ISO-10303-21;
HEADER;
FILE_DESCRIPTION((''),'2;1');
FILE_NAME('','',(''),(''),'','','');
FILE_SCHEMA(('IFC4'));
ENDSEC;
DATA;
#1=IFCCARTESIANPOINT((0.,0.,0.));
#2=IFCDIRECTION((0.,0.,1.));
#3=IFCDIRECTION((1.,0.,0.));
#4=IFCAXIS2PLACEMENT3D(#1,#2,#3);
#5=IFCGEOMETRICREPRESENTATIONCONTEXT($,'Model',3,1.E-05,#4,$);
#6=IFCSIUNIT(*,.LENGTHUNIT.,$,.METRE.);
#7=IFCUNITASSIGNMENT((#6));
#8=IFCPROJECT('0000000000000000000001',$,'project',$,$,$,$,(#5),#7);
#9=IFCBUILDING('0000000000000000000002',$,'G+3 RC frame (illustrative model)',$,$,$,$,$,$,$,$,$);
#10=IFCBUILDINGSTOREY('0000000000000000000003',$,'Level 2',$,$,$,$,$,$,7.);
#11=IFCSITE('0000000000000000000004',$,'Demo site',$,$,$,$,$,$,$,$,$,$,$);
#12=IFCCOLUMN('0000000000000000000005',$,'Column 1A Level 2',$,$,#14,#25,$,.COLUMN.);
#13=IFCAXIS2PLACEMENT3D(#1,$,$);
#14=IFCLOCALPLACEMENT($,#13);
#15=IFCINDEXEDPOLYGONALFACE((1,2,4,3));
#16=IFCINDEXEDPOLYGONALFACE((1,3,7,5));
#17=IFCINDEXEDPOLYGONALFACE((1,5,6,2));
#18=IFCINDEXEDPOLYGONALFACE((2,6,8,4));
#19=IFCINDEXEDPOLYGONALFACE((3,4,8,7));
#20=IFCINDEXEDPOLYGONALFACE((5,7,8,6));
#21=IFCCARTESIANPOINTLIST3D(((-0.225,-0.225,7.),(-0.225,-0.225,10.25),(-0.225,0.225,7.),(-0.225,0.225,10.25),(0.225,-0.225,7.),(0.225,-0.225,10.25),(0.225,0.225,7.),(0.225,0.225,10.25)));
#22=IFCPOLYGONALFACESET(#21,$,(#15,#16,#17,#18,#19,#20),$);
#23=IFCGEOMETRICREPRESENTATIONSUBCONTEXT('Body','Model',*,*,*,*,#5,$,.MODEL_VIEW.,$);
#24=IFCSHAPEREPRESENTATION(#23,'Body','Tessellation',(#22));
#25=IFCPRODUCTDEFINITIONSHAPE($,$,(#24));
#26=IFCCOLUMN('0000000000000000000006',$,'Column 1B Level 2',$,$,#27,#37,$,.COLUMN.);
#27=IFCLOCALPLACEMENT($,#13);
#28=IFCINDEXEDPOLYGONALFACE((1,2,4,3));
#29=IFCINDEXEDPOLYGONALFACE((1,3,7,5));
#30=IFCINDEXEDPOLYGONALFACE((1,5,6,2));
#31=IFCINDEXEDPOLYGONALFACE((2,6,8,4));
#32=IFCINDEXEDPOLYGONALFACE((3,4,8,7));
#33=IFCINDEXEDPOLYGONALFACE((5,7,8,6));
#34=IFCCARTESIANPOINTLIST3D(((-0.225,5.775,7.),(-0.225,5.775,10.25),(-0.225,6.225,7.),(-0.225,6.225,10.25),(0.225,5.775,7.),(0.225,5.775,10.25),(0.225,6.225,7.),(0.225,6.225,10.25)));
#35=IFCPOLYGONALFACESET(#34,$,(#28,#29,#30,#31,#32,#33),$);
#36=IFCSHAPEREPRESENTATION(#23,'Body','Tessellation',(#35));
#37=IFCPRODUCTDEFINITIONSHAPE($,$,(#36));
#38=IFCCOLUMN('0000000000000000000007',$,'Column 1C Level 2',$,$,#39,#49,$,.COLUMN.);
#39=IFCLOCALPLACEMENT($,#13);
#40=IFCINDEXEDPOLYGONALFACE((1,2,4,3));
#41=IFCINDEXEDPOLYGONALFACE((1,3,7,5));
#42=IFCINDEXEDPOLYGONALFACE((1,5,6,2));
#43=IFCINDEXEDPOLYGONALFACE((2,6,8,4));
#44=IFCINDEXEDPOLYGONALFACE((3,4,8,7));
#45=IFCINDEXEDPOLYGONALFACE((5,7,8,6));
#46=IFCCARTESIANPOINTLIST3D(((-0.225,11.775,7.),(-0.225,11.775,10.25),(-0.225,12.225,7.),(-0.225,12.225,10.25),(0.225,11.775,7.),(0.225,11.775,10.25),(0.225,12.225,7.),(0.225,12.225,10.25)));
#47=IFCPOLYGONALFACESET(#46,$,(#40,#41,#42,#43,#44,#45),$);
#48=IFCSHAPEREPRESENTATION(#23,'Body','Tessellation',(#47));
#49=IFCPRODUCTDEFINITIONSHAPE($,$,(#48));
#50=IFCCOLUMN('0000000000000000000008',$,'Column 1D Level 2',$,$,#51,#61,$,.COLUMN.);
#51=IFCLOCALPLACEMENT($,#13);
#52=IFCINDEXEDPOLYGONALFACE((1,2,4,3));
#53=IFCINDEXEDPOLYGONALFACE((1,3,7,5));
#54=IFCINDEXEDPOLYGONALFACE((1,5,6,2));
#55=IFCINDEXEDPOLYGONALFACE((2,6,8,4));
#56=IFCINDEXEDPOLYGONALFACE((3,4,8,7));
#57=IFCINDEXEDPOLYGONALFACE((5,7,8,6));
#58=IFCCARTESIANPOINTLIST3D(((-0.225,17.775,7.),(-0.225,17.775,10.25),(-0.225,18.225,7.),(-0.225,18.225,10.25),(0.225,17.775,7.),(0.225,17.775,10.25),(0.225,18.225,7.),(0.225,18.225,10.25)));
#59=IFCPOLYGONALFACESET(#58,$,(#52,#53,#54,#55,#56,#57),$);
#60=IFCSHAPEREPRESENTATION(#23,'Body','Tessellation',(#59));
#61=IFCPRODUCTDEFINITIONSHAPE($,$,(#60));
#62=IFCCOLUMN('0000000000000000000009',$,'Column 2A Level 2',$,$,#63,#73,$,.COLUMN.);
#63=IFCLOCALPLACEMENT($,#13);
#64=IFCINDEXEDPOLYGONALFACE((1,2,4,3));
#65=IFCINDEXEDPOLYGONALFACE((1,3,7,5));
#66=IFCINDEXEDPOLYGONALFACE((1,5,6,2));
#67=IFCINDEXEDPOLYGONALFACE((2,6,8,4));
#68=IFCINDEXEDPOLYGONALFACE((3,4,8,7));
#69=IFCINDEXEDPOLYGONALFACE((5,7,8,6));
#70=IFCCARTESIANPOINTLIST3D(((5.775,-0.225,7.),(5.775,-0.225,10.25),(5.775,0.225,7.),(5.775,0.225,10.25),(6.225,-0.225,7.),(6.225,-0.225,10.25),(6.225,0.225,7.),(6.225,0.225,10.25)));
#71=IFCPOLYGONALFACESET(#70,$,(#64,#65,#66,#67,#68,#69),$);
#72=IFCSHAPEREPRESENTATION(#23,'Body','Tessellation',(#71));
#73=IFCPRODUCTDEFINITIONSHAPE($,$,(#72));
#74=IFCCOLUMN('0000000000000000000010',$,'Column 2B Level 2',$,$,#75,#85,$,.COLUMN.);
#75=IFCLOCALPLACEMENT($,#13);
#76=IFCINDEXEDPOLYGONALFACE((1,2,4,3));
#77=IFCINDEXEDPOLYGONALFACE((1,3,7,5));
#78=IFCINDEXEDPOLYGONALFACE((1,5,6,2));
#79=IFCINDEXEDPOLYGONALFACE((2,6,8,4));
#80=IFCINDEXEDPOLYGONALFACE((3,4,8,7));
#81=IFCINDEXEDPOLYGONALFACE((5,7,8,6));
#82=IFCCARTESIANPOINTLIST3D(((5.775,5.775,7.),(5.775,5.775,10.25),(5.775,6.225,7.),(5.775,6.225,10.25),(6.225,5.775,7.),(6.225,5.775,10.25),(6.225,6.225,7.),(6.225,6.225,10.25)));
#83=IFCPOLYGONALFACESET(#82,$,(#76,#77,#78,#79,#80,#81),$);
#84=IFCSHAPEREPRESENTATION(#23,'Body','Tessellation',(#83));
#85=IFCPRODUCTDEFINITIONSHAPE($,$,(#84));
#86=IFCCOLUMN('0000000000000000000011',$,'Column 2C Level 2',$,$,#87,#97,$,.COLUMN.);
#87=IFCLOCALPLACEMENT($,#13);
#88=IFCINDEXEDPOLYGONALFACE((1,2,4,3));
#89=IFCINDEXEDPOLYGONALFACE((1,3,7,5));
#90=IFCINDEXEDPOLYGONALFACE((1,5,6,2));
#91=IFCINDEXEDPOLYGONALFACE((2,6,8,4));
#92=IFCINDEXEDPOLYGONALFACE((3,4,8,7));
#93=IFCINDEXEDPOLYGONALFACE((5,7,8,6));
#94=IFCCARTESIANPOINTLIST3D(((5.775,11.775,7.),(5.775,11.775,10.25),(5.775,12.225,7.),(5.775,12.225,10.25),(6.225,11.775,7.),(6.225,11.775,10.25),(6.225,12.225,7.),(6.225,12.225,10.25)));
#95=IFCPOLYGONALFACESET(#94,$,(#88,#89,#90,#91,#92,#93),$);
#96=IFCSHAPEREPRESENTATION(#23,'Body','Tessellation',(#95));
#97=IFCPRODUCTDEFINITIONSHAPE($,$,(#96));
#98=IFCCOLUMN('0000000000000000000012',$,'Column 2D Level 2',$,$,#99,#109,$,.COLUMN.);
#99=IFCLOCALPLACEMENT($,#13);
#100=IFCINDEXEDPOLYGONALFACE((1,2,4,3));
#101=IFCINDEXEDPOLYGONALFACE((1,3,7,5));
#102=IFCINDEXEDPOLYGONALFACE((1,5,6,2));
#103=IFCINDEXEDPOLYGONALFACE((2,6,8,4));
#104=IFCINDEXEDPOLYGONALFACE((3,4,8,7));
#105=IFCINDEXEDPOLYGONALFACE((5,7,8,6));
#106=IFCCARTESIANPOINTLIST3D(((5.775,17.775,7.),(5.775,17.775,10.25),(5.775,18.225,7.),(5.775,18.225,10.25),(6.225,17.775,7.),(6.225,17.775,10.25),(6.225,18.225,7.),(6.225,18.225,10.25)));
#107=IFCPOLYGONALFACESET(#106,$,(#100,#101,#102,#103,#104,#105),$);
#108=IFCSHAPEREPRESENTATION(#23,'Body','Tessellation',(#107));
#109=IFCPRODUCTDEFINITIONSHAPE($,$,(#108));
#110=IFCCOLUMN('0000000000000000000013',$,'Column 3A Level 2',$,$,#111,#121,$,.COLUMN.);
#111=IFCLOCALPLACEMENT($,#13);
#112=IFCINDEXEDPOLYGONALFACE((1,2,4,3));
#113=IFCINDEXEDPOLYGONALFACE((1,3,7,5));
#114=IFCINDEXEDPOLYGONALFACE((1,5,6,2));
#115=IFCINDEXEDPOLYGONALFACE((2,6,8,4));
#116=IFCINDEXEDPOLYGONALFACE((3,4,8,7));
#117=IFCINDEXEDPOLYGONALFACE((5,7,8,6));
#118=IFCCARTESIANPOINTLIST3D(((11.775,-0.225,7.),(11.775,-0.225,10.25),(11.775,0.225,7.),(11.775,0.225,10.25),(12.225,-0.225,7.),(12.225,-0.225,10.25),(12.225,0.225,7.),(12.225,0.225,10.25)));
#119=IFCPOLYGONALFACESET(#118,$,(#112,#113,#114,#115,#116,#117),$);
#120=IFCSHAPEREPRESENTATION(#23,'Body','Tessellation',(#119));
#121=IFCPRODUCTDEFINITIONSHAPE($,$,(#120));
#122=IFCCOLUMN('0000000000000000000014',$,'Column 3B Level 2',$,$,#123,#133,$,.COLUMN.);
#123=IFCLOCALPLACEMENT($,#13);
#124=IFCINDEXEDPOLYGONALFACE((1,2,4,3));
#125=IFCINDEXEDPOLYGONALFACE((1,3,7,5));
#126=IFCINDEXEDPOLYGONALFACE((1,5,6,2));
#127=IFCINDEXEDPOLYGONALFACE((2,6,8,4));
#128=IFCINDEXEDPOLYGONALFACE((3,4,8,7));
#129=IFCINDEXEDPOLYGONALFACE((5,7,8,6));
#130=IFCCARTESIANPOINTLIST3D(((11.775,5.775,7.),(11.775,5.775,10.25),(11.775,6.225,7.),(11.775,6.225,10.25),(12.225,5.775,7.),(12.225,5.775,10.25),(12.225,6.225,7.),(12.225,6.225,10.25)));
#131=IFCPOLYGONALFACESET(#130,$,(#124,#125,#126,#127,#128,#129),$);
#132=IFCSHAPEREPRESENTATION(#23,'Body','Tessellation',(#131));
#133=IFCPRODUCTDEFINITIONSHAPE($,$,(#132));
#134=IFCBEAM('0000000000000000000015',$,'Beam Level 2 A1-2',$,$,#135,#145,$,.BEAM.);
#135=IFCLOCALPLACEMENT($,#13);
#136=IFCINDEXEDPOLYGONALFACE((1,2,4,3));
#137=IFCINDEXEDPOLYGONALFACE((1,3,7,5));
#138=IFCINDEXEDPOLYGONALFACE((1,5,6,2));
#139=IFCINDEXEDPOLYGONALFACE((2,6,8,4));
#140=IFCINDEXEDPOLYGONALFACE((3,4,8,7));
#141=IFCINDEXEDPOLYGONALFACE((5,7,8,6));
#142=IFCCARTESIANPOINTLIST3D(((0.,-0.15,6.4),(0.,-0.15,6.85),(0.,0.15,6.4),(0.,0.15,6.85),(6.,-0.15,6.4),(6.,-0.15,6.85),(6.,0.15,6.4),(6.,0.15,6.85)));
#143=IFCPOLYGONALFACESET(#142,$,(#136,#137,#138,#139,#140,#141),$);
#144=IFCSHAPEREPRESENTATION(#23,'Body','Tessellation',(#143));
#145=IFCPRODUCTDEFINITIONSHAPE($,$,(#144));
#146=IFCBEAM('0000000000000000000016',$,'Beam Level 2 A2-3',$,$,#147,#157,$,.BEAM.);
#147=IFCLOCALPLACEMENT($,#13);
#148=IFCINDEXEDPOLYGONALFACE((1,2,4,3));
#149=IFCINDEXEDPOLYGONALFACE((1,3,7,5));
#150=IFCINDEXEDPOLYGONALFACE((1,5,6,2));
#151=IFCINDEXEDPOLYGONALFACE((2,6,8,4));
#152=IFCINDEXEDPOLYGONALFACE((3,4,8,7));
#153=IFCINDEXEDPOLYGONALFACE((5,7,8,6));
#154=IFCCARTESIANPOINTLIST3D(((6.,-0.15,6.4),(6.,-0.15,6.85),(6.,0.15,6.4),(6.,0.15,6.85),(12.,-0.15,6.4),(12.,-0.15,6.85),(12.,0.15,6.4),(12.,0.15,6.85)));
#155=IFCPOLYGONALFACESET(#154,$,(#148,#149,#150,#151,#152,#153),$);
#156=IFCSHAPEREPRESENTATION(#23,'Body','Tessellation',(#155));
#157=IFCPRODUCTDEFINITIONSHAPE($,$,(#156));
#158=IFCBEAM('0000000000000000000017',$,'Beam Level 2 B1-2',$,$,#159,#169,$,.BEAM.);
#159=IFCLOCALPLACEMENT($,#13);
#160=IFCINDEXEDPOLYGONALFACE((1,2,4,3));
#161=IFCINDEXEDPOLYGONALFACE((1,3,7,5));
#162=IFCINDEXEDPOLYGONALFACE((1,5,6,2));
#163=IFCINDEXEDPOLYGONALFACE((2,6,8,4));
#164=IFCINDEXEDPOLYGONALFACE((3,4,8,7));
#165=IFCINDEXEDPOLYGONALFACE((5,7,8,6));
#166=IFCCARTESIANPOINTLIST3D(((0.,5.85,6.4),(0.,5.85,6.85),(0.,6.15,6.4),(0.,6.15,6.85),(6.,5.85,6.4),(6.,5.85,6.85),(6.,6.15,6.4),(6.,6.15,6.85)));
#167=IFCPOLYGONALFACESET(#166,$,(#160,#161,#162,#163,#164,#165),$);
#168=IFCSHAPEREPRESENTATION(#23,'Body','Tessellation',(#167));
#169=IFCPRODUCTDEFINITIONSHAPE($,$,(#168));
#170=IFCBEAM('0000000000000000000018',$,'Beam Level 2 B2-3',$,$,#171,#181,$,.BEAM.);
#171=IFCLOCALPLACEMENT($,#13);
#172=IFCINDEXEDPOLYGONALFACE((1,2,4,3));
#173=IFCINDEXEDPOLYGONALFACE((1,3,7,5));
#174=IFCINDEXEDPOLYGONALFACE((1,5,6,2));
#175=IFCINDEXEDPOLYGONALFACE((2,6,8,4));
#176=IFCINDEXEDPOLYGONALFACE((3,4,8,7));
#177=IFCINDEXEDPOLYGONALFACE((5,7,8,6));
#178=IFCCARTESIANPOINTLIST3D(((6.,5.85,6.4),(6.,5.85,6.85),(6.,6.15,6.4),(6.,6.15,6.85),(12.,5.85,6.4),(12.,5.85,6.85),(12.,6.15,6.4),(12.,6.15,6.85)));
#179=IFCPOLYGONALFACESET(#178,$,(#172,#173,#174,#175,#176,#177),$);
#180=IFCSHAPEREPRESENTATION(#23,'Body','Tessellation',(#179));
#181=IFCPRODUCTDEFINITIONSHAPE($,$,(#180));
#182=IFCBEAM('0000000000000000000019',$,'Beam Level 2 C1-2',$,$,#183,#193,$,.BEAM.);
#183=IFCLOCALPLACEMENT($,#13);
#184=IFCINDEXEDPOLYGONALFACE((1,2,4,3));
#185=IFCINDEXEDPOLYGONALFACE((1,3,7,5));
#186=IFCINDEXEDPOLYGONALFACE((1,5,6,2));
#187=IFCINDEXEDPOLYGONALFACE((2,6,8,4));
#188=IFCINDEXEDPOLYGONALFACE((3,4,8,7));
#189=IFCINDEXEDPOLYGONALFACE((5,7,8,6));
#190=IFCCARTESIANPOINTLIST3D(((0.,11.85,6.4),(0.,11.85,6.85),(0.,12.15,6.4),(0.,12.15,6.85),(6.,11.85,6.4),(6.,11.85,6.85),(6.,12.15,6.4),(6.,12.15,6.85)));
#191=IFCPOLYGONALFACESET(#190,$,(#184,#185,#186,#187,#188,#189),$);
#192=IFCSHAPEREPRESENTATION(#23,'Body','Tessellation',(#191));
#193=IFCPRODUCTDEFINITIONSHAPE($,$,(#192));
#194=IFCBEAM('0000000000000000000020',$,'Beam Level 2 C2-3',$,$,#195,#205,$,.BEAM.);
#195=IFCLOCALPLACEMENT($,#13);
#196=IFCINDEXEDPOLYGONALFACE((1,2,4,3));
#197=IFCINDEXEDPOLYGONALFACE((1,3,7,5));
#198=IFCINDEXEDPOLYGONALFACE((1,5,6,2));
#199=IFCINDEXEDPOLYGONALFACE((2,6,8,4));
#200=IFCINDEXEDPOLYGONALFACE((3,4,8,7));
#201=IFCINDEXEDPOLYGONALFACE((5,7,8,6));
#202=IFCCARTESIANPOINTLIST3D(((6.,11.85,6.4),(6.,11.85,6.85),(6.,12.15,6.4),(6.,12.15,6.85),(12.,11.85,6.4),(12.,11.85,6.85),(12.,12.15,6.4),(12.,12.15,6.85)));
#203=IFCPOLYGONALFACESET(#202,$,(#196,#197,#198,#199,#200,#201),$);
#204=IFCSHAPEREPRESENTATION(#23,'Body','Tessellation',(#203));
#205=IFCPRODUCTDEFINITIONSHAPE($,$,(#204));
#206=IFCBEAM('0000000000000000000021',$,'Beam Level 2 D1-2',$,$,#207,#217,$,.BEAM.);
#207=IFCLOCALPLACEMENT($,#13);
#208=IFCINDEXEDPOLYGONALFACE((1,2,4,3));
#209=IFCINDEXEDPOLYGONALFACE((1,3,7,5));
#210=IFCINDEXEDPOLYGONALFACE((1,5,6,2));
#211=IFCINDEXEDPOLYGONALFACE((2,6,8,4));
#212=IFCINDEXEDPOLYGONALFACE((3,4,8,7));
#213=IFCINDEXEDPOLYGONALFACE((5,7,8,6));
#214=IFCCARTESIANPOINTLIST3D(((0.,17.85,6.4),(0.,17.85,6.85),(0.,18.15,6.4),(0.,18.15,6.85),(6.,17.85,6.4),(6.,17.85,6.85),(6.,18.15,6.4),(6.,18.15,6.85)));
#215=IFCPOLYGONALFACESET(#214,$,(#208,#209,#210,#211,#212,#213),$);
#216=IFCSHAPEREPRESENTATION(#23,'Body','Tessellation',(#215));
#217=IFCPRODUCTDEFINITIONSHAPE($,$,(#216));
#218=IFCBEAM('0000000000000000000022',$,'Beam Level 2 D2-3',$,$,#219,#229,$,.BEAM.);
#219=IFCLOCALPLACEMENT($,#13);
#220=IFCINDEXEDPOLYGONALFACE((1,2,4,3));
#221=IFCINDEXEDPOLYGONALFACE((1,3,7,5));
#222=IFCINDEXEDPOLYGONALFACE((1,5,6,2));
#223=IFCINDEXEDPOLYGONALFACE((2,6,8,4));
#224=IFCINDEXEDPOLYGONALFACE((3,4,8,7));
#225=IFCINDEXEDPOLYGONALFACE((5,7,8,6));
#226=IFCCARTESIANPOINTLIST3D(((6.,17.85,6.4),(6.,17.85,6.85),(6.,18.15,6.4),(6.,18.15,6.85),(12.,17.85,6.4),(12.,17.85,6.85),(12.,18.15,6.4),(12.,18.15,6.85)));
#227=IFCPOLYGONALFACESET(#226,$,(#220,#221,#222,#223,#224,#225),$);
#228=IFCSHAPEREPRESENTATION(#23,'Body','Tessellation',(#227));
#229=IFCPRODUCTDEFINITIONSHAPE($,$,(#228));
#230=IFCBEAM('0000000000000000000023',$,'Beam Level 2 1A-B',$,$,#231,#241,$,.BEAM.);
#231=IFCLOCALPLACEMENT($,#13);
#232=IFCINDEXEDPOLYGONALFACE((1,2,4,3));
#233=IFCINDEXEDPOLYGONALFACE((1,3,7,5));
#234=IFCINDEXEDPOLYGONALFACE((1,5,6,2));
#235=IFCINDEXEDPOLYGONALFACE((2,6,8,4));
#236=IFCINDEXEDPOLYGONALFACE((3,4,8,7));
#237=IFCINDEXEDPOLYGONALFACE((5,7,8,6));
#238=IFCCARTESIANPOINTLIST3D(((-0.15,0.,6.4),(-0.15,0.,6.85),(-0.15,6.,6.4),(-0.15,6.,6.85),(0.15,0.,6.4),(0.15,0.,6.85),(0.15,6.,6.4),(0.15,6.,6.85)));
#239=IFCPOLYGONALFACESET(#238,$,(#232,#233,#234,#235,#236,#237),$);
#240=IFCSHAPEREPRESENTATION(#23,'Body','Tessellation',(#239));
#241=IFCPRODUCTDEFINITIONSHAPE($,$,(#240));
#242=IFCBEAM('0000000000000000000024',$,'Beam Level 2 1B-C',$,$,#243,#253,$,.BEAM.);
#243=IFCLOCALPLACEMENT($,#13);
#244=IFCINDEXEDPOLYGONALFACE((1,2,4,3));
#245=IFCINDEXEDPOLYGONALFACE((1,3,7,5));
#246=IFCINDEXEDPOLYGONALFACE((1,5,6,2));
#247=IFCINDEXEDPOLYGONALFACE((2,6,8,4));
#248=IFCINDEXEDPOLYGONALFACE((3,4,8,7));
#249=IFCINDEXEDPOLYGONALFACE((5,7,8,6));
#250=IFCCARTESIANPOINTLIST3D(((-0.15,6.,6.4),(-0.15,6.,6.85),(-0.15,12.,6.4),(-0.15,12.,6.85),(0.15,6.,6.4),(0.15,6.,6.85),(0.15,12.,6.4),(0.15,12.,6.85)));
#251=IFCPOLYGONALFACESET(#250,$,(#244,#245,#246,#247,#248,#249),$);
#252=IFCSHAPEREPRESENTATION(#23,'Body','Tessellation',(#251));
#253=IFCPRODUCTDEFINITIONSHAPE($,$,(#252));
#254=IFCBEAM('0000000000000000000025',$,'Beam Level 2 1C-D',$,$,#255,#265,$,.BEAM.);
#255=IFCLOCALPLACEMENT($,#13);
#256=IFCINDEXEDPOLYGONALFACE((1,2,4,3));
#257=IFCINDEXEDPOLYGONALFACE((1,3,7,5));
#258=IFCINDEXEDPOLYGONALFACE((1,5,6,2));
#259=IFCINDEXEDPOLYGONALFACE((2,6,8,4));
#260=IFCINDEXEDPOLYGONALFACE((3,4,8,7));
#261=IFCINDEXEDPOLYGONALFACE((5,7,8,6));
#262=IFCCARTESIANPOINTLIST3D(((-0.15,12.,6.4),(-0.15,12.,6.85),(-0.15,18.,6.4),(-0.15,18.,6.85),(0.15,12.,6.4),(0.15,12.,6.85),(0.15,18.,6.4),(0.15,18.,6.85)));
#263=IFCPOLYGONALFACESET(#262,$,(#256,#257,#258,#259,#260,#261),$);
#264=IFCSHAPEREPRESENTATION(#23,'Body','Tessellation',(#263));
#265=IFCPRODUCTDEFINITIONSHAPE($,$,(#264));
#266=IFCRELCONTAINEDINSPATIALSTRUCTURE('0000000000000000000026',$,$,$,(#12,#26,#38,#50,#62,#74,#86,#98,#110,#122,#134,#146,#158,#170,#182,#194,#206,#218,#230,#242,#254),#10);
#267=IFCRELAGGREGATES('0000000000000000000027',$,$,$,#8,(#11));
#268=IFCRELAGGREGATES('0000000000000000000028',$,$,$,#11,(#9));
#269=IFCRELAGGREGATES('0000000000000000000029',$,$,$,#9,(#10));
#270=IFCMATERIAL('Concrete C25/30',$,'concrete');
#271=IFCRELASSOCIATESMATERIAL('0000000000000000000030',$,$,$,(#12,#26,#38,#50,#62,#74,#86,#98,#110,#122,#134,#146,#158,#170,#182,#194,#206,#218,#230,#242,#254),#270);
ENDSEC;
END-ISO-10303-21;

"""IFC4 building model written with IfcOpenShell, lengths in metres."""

from ifc_helpers import new_model, si_unit, frame, frame_2d, origin, origin_with_axes, place, context, subcontext, project, spatial, rectangle, extrude, material, element, save


model = new_model("IFC4")

# Units and contexts
model_context = context("Model", 3, precision=1e-05, world=origin_with_axes())
body_context = subcontext(model_context, "Body", "Model", "MODEL_VIEW")
ifc_project = project(units=[si_unit("LENGTHUNIT", "METRE")], contexts=[model_context])

# Site, building, storey
site = spatial("IfcSite", under=ifc_project, Name="Demo site")
building = spatial("IfcBuilding", under=site, Name="G+3 RC frame (illustrative model)")
storey = spatial("IfcBuildingStorey", under=building, Name="Level 2", Elevation=7.0)

# Columns
ifc_material_1 = material(Name="Concrete C25/30", Category="concrete")
for number, where, z_axis, x_axis, name in (
    (1, (-0.225, -0.225, 7.0), (0.0, 0.0, 1.0), (1.0, 0.0, 0.0), "Column 1A Level 2"),
    (2, (-0.225, 5.775, 7.0), (0.0, 0.0, 1.0), (1.0, 0.0, 0.0), "Column 1B Level 2"),
    (3, (-0.225, 11.775, 7.0), (0.0, 0.0, 1.0), (1.0, 0.0, 0.0), "Column 1C Level 2"),
    (4, (-0.225, 17.775, 7.0), (0.0, 0.0, 1.0), (1.0, 0.0, 0.0), "Column 1D Level 2"),
    (5, (5.775, -0.225, 7.0), (0.0, 0.0, 1.0), (1.0, 0.0, 0.0), "Column 2A Level 2"),
    (6, (5.775, 5.775, 7.0), (0.0, 0.0, 1.0), (1.0, 0.0, 0.0), "Column 2B Level 2"),
    (7, (5.775, 11.775, 7.0), (0.0, 0.0, 1.0), (1.0, 0.0, 0.0), "Column 2C Level 2"),
    (8, (5.775, 17.775, 7.0), (0.0, 0.0, 1.0), (1.0, 0.0, 0.0), "Column 2D Level 2"),
    (9, (11.775, -0.225, 7.0), (0.0, 0.0, 1.0), (1.0, 0.0, 0.0), "Column 3A Level 2"),
    (10, (11.775, 5.775, 7.0), (0.0, 0.0, 1.0), (1.0, 0.0, 0.0), "Column 3B Level 2"),
):
    element("IfcColumn", number, at=place(None, frame(where, z_axis=z_axis, x_axis=x_axis)), inside=storey, material=ifc_material_1, Name=name, PredefinedType="COLUMN", context=body_context, shape_type="SweptSolid", body=[
        extrude(rectangle(XDim=0.45, YDim=0.45, at=frame_2d((0.225, 0.225))), origin(), (0.0, 0.0, 1.0), 3.25),
    ])

# Beams
for number, where, z_axis, x_axis, name in (
    (11, (0.0, -0.15, 6.4), (0.0, 0.0, 1.0), (1.0, 0.0, 0.0), "Beam Level 2 A1-2"),
    (12, (6.0, -0.15, 6.4), (0.0, 0.0, 1.0), (1.0, 0.0, 0.0), "Beam Level 2 A2-3"),
    (13, (0.0, 5.85, 6.4), (0.0, 0.0, 1.0), (1.0, 0.0, 0.0), "Beam Level 2 B1-2"),
    (14, (6.0, 5.85, 6.4), (0.0, 0.0, 1.0), (1.0, 0.0, 0.0), "Beam Level 2 B2-3"),
    (15, (0.0, 11.85, 6.4), (0.0, 0.0, 1.0), (1.0, 0.0, 0.0), "Beam Level 2 C1-2"),
    (16, (6.0, 11.85, 6.4), (0.0, 0.0, 1.0), (1.0, 0.0, 0.0), "Beam Level 2 C2-3"),
    (17, (0.0, 17.85, 6.4), (0.0, 0.0, 1.0), (1.0, 0.0, 0.0), "Beam Level 2 D1-2"),
    (18, (6.0, 17.85, 6.4), (0.0, 0.0, 1.0), (1.0, 0.0, 0.0), "Beam Level 2 D2-3"),
):
    element("IfcBeam", number, at=place(None, frame(where, z_axis=z_axis, x_axis=x_axis)), inside=storey, material=ifc_material_1, Name=name, PredefinedType="BEAM", context=body_context, shape_type="SweptSolid", body=[
        extrude(rectangle(XDim=6.0, YDim=0.3, at=frame_2d((3.0, 0.15))), origin(), (0.0, 0.0, 1.0), 0.45),
    ])
for number, where, z_axis, x_axis, name in (
    (19, (-0.15, 0.0, 6.4), (0.0, 0.0, 1.0), (1.0, 0.0, 0.0), "Beam Level 2 1A-B"),
    (20, (-0.15, 6.0, 6.4), (0.0, 0.0, 1.0), (1.0, 0.0, 0.0), "Beam Level 2 1B-C"),
    (21, (-0.15, 12.0, 6.4), (0.0, 0.0, 1.0), (1.0, 0.0, 0.0), "Beam Level 2 1C-D"),
):
    element("IfcBeam", number, at=place(None, frame(where, z_axis=z_axis, x_axis=x_axis)), inside=storey, material=ifc_material_1, Name=name, PredefinedType="BEAM", context=body_context, shape_type="SweptSolid", body=[
        extrude(rectangle(XDim=0.3, YDim=6.0, at=frame_2d((0.15, 3.0))), origin(), (0.0, 0.0, 1.0), 0.45),
    ])

save(model, "model.ifc")
